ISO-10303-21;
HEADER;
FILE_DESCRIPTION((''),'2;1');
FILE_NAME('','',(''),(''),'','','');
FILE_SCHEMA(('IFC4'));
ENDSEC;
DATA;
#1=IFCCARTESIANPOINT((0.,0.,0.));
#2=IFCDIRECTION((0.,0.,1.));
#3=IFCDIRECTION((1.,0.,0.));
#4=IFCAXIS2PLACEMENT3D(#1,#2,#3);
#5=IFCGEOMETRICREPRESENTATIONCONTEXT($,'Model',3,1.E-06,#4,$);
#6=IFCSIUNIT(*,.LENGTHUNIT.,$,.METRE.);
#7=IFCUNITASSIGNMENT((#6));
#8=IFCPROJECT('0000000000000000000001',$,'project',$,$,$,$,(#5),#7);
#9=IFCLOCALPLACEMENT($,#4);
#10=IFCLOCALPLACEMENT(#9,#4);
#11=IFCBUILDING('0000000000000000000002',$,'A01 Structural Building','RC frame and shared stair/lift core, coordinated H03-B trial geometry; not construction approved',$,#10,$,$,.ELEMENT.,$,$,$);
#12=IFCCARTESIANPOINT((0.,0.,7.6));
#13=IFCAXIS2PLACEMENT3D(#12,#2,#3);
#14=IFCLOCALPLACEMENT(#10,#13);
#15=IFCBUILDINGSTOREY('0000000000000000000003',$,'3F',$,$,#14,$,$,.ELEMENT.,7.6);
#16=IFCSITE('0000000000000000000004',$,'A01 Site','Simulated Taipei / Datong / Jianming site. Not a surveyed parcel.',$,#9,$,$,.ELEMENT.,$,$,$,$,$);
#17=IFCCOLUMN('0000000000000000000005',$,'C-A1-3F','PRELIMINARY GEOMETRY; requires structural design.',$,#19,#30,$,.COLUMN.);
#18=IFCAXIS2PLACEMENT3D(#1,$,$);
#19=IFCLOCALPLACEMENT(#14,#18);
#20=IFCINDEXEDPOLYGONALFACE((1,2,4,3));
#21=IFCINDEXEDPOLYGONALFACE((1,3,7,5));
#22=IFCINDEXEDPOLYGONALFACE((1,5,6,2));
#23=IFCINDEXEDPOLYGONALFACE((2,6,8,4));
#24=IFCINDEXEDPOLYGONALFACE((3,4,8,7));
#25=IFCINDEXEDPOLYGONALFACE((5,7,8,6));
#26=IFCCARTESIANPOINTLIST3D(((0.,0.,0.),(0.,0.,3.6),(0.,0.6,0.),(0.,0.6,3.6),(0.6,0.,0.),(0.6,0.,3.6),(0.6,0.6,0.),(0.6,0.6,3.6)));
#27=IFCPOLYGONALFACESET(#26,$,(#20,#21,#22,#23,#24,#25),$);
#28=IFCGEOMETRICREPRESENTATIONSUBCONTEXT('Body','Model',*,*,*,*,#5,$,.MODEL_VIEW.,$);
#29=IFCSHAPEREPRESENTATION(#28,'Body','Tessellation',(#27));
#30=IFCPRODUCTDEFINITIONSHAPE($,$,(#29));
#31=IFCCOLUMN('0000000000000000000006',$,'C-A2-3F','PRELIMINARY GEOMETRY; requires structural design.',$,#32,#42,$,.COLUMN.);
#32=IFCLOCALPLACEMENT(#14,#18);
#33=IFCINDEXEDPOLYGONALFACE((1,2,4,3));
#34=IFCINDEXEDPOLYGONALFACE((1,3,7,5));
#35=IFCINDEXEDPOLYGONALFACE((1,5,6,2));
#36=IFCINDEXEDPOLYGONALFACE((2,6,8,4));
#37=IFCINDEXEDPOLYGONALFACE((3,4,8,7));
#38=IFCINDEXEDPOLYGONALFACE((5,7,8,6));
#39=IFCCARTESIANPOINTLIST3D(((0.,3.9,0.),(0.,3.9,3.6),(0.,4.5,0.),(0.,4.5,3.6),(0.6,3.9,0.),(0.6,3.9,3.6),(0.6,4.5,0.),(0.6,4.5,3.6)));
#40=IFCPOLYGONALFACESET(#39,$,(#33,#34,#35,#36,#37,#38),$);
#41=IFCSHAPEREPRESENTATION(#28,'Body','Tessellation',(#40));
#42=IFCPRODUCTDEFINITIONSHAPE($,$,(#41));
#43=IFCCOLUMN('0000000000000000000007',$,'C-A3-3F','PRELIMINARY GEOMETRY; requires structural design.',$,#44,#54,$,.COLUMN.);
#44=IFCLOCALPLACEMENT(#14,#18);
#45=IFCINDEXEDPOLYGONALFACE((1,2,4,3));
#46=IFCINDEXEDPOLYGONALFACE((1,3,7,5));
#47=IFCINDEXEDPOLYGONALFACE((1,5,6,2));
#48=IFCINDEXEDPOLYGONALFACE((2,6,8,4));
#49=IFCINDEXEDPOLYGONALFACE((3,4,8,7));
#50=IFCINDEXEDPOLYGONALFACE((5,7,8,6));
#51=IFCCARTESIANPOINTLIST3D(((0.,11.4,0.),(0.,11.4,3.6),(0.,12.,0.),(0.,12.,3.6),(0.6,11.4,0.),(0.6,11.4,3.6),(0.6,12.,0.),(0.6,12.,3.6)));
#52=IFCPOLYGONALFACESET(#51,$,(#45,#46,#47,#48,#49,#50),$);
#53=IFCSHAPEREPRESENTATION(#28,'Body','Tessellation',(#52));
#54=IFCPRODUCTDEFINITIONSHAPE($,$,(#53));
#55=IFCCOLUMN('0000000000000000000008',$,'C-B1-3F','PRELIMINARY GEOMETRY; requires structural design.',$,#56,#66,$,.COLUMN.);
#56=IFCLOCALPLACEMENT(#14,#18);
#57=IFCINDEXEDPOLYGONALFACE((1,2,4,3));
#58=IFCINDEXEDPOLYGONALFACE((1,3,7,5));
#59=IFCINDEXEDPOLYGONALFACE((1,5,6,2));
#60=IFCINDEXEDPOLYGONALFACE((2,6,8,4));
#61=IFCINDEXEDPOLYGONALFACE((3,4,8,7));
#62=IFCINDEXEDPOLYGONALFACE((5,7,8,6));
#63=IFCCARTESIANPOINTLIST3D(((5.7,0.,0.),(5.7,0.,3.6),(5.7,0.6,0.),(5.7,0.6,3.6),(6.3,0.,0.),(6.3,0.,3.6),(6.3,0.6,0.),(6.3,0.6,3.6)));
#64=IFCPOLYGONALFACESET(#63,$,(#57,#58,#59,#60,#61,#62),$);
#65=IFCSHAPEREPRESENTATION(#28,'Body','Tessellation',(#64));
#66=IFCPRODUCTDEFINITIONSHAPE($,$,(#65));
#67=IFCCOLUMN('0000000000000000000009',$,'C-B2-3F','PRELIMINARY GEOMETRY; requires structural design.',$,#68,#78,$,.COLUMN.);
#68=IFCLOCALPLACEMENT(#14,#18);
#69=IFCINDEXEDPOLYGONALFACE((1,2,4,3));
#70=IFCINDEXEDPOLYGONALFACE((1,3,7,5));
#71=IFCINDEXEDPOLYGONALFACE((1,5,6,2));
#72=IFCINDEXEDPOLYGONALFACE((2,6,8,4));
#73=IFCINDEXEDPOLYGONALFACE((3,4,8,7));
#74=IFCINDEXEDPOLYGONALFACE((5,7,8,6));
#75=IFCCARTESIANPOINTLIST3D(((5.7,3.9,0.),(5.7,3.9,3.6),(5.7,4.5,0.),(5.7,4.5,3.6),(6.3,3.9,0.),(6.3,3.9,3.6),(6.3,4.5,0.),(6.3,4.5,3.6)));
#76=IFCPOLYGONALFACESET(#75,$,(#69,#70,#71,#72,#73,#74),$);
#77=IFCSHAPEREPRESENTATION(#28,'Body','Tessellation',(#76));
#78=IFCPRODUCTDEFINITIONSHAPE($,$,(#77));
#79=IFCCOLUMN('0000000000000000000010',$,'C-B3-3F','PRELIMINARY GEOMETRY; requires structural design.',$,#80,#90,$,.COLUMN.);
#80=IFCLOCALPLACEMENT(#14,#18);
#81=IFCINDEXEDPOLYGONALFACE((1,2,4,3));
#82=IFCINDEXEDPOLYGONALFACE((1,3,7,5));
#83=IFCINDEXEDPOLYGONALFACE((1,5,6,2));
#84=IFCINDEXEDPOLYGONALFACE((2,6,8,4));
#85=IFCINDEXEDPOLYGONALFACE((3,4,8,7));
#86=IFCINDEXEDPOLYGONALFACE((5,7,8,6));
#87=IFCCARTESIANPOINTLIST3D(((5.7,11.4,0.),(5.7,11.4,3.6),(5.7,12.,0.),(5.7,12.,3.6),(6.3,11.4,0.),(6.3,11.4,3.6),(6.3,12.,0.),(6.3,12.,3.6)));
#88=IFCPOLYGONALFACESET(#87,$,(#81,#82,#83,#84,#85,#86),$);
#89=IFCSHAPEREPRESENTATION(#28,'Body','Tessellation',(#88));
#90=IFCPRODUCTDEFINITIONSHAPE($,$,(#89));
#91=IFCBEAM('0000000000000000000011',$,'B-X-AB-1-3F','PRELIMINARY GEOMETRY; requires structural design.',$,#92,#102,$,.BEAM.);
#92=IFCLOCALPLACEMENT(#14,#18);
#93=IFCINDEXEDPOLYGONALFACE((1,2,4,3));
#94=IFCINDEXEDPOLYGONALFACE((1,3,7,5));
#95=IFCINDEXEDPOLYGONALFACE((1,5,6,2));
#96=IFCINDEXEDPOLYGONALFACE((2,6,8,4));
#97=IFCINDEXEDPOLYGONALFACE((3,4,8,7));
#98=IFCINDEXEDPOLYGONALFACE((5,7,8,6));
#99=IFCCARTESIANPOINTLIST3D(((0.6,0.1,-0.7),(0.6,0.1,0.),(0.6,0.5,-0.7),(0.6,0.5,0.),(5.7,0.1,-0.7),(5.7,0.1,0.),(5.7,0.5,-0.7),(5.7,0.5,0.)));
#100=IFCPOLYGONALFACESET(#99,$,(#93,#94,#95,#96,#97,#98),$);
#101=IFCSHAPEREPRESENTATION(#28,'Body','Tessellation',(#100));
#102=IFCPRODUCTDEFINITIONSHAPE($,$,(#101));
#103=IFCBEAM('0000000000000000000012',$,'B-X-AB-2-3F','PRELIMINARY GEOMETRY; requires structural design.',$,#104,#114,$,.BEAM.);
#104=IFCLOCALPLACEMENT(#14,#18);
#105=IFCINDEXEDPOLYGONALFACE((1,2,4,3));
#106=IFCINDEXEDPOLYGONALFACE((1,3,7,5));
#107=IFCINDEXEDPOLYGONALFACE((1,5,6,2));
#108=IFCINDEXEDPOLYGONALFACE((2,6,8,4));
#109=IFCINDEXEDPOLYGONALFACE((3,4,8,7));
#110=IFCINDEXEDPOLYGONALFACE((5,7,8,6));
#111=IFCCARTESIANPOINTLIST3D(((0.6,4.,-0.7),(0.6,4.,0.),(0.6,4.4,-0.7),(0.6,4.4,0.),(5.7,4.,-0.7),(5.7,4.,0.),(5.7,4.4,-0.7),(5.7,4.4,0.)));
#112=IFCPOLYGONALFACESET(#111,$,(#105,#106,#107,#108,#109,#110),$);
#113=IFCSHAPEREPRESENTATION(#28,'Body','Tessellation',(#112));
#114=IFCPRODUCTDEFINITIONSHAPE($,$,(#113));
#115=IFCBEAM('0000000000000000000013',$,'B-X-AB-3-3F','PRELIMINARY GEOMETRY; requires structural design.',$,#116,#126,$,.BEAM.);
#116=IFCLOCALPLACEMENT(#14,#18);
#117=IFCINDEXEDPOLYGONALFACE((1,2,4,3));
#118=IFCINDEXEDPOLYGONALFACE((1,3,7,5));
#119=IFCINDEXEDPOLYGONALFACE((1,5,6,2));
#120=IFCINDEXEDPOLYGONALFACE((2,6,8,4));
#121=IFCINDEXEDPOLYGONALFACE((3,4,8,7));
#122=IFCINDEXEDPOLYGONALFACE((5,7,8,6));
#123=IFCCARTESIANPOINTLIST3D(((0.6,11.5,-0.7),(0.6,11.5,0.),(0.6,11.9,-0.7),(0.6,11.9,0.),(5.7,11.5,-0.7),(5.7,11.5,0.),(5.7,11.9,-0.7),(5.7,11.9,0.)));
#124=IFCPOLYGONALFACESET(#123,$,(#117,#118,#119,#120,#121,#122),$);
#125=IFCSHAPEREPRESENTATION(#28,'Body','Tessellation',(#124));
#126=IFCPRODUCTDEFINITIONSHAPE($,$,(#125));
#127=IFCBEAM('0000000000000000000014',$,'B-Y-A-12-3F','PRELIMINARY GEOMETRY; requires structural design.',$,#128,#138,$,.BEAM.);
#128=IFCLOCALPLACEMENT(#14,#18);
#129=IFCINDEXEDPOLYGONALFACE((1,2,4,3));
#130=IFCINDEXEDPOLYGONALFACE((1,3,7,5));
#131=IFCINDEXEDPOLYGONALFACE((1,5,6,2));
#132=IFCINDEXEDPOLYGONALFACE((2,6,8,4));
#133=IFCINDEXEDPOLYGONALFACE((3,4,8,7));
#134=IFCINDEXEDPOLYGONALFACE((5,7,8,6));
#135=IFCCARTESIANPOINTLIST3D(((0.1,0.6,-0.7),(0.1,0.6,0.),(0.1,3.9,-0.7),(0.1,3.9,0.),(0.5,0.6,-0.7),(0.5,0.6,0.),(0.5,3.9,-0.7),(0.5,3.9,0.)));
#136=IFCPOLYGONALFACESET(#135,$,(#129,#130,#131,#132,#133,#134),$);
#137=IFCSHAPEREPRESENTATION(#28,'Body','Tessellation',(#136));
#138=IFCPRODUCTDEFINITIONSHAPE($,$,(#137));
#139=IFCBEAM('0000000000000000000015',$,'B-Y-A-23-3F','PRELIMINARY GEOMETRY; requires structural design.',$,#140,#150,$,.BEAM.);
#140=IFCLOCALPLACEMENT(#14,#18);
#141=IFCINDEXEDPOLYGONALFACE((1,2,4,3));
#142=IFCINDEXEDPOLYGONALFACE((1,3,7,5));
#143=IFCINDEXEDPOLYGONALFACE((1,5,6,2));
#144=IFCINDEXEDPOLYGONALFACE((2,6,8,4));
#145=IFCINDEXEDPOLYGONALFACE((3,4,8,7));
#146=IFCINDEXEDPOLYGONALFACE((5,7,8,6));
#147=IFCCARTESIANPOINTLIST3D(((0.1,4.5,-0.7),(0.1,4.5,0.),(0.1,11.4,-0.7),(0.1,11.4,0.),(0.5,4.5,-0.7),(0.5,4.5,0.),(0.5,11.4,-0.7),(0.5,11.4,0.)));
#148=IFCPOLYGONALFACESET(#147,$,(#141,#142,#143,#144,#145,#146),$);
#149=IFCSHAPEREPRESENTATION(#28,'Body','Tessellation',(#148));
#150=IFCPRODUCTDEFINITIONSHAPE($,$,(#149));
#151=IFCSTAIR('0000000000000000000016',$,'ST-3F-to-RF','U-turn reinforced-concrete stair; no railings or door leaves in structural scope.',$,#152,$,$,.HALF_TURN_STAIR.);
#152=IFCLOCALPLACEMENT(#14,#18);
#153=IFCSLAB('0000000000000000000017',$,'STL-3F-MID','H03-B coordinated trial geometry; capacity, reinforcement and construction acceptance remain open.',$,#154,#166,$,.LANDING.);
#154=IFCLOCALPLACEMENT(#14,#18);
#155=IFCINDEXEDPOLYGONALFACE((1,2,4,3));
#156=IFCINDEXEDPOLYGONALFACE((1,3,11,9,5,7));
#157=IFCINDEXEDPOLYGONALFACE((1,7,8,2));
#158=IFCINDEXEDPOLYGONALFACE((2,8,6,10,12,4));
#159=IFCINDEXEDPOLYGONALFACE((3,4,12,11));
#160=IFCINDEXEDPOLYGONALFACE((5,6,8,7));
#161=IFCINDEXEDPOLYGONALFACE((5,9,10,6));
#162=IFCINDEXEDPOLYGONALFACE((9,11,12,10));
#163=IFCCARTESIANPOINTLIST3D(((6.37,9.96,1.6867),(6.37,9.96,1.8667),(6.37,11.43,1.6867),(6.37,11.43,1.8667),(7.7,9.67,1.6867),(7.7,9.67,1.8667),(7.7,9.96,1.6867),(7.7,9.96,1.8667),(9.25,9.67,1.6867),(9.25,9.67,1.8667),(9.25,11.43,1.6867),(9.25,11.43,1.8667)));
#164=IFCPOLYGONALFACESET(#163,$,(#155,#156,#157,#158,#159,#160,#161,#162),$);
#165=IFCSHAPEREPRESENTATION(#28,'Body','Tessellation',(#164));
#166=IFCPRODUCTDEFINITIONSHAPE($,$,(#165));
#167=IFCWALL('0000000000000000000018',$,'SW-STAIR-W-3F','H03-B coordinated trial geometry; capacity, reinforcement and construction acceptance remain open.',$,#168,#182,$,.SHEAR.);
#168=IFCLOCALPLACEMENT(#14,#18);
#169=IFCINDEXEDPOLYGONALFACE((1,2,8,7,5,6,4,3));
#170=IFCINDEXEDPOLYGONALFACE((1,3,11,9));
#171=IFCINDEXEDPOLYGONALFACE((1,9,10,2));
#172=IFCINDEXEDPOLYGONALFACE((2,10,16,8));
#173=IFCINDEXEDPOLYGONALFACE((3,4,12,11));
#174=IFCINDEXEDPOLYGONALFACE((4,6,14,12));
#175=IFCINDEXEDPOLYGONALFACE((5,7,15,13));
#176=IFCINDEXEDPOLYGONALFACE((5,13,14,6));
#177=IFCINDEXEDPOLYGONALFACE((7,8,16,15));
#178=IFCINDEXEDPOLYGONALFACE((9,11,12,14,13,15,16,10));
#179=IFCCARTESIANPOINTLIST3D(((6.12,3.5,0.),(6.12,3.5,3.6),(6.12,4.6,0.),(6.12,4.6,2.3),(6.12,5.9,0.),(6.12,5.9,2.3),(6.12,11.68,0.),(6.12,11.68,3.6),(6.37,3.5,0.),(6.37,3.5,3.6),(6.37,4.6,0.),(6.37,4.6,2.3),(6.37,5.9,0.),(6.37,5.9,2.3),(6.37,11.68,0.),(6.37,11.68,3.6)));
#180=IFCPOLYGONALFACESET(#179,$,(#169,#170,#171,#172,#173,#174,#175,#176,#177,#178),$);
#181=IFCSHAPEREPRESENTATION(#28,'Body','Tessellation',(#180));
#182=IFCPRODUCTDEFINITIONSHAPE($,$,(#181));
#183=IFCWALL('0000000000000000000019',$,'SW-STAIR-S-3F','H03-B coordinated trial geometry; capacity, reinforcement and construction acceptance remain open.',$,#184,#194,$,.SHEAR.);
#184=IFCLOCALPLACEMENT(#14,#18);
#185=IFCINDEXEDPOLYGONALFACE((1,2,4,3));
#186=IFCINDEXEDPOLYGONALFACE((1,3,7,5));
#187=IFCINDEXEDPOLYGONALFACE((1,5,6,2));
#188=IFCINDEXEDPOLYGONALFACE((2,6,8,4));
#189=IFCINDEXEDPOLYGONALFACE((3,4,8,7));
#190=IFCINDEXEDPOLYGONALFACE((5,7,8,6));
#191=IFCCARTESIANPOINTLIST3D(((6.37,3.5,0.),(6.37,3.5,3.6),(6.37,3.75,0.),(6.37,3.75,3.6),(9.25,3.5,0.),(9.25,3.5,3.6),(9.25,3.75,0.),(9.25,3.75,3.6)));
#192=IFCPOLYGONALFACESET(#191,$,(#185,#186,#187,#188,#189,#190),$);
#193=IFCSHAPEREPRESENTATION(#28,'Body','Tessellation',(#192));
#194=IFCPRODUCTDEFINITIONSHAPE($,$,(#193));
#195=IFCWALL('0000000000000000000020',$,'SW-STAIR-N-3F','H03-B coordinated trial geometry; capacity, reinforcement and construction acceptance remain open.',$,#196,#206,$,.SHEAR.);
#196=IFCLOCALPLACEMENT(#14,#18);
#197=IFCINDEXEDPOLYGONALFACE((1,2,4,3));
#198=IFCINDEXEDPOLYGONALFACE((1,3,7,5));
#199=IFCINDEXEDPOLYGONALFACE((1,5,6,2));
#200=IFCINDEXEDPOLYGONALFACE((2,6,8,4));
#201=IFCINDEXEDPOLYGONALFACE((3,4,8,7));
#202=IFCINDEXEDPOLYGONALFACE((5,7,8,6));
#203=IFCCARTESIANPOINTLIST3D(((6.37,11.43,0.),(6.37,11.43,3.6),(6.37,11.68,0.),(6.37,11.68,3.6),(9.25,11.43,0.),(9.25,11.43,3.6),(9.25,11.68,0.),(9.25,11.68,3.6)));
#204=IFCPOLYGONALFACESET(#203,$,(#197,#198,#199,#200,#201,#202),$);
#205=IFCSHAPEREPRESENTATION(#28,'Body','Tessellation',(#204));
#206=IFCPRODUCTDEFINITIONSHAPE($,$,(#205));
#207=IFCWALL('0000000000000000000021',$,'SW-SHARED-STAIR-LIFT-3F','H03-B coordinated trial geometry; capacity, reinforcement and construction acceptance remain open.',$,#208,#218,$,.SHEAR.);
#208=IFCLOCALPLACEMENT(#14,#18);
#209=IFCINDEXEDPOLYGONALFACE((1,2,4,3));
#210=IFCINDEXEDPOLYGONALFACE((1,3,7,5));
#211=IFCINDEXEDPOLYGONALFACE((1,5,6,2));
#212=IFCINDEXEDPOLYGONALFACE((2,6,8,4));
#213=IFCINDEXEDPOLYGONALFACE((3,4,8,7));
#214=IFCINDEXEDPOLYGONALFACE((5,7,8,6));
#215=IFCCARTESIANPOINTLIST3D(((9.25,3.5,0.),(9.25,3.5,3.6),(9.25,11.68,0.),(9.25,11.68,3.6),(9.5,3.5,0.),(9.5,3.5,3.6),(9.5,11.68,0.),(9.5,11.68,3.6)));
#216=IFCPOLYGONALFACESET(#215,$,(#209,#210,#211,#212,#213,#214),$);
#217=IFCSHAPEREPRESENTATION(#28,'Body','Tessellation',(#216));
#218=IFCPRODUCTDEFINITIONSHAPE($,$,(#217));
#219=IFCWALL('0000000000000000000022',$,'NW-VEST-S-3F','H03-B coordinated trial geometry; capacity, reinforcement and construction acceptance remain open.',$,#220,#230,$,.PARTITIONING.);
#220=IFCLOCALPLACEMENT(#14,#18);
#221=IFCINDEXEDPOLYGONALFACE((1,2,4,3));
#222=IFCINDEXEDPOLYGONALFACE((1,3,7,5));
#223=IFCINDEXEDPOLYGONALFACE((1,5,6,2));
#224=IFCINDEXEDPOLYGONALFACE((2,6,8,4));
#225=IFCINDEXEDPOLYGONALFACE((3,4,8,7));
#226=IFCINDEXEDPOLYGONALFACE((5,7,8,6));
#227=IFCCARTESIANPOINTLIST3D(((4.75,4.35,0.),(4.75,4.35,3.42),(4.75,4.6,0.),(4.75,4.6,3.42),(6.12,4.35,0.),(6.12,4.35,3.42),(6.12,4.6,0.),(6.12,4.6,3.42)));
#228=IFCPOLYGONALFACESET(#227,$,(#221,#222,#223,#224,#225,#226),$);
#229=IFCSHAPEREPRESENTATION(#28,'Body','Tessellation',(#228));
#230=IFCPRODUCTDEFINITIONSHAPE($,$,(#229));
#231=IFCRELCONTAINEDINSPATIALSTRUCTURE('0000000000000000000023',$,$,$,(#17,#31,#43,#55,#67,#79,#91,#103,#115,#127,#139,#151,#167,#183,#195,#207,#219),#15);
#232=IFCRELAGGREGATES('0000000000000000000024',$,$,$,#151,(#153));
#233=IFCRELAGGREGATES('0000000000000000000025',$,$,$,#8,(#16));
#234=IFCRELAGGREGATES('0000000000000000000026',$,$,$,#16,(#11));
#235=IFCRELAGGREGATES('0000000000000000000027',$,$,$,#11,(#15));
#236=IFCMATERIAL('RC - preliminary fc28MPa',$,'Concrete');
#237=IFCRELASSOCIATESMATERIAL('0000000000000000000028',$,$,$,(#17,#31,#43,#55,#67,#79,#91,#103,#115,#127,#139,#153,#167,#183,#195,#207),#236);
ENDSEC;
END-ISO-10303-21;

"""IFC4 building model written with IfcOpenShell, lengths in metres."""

from ifc_helpers import new_model, si_unit, frame, origin_with_axes, place, context, subcontext, project, spatial, polyline, rectangle, outline, extrude, material, element, aggregate, save


model = new_model("IFC4")

# Units and contexts
model_context = context("Model", 3, precision=1e-06, world=origin_with_axes())
body_context = subcontext(model_context, "Body", "Model", "MODEL_VIEW")
ifc_project = project(units=[si_unit("LENGTHUNIT", "METRE")], contexts=[model_context])

# Site, building, storey
site_placement = place(None, origin_with_axes())
site = spatial("IfcSite", under=ifc_project, at=site_placement, Name="A01 Site", Description="Simulated Taipei / Datong / Jianming site. Not a surveyed parcel.", CompositionType="ELEMENT")
building_placement = place(site_placement, origin_with_axes())
building = spatial("IfcBuilding", under=site, at=building_placement, Name="A01 Structural Building", Description="RC frame and shared stair/lift core, coordinated H03-B trial geometry; not construction approved", CompositionType="ELEMENT")
storey_placement = place(building_placement, frame((0.0, 0.0, 7.6), z_axis=(0.0, 0.0, 1.0), x_axis=(1.0, 0.0, 0.0)))
storey = spatial("IfcBuildingStorey", under=building, at=storey_placement, Name="3F", CompositionType="ELEMENT", Elevation=7.6)

# Columns
ifc_material = material(Name="RC - preliminary fc28MPa", Category="Concrete")
for number, where, z_axis, x_axis, name in (
    (1, (0.3, 0.3, 0.0), (0.0, 0.0, 1.0), (1.0, 0.0, 0.0), "C-A1-3F"),
    (2, (0.3, 4.2, 0.0), (0.0, 0.0, 1.0), (1.0, 0.0, 0.0), "C-A2-3F"),
    (3, (0.3, 11.7, 0.0), (0.0, 0.0, 1.0), (1.0, 0.0, 0.0), "C-A3-3F"),
    (4, (6.0, 0.3, 0.0), (0.0, 0.0, 1.0), (1.0, 0.0, 0.0), "C-B1-3F"),
    (5, (6.0, 4.2, 0.0), (0.0, 0.0, 1.0), (1.0, 0.0, 0.0), "C-B2-3F"),
    (6, (6.0, 11.7, 0.0), (0.0, 0.0, 1.0), (1.0, 0.0, 0.0), "C-B3-3F"),
):
    element("IfcColumn", number, at=place(storey_placement, frame(where, z_axis=z_axis, x_axis=x_axis)), inside=storey, material=ifc_material, Name=name, Description="PRELIMINARY GEOMETRY; requires structural design.", PredefinedType="COLUMN", context=body_context, shape_type="SweptSolid", body=[
        extrude(rectangle(XDim=0.6, YDim=0.6), origin_with_axes(), (0.0, 0.0, 1.0), 3.6),
    ])

# Beams
for number, where, z_axis, x_axis, name in (
    (7, (3.15, 0.3, -0.7), (0.0, 0.0, 1.0), (1.0, 0.0, 0.0), "B-X-AB-1-3F"),
    (8, (3.15, 4.2, -0.7), (0.0, 0.0, 1.0), (1.0, 0.0, 0.0), "B-X-AB-2-3F"),
    (9, (3.15, 11.7, -0.7), (0.0, 0.0, 1.0), (1.0, 0.0, 0.0), "B-X-AB-3-3F"),
):
    element("IfcBeam", number, at=place(storey_placement, frame(where, z_axis=z_axis, x_axis=x_axis)), inside=storey, material=ifc_material, Name=name, Description="PRELIMINARY GEOMETRY; requires structural design.", PredefinedType="BEAM", context=body_context, shape_type="SweptSolid", body=[
        extrude(rectangle(XDim=5.1, YDim=0.4), origin_with_axes(), (0.0, 0.0, 1.0), 0.7),
    ])
beam_1_placement = place(storey_placement, frame((0.3, 2.25, -0.7), z_axis=(0.0, 0.0, 1.0), x_axis=(1.0, 0.0, 0.0)))
element("IfcBeam", 10, at=beam_1_placement, inside=storey, material=ifc_material, Name="B-Y-A-12-3F", Description="PRELIMINARY GEOMETRY; requires structural design.", PredefinedType="BEAM", context=body_context, shape_type="SweptSolid", body=[
    extrude(rectangle(XDim=0.4, YDim=3.3), origin_with_axes(), (0.0, 0.0, 1.0), 0.7),
])
beam_2_placement = place(storey_placement, frame((0.3, 7.95, -0.7), z_axis=(0.0, 0.0, 1.0), x_axis=(1.0, 0.0, 0.0)))
element("IfcBeam", 11, at=beam_2_placement, inside=storey, material=ifc_material, Name="B-Y-A-23-3F", Description="PRELIMINARY GEOMETRY; requires structural design.", PredefinedType="BEAM", context=body_context, shape_type="SweptSolid", body=[
    extrude(rectangle(XDim=0.4, YDim=6.9), origin_with_axes(), (0.0, 0.0, 1.0), 0.7),
])

# Stair, slab
stair_placement = place(storey_placement, origin_with_axes())
stair = element("IfcStair", 12, at=stair_placement, inside=storey, Name="ST-3F-to-RF", Description="U-turn reinforced-concrete stair; no railings or door leaves in structural scope.", PredefinedType="HALF_TURN_STAIR")
placement = place(None, origin_with_axes())
slab = element("IfcSlab", 13, at=placement, material=ifc_material, Name="STL-3F-MID", Description="H03-B coordinated trial geometry; capacity, reinforcement and construction acceptance remain open.", PredefinedType="LANDING", context=body_context, shape_type="SweptSolid", body=[
    extrude(outline(polyline([(6.37, 9.96), (7.7, 9.96), (7.7, 9.67), (9.25, 9.67), (9.25, 11.43), (6.37, 11.43), (6.37, 9.96)])), frame((0.0, 0.0, 9.2867), z_axis=(0.0, 0.0, 1.0), x_axis=(1.0, 0.0, 0.0)), (0.0, 0.0, 1.0), 0.18),
])

# Wall, opening
wall_1 = element("IfcWall", 14, at=placement, inside=storey, material=ifc_material, Name="SW-STAIR-W-3F", Description="H03-B coordinated trial geometry; capacity, reinforcement and construction acceptance remain open.", PredefinedType="SHEAR", context=body_context, shape_type="SweptSolid", body=[
    extrude(outline(polyline([(6.37, 3.5), (6.37, 11.68), (6.12, 11.68), (6.12, 3.5), (6.37, 3.5)])), frame((0.0, 0.0, 7.6), z_axis=(0.0, 0.0, 1.0), x_axis=(1.0, 0.0, 0.0)), (0.0, 0.0, 1.0), 3.6),
])
element("IfcOpeningElement", 15, at=placement, cuts=wall_1, PredefinedType="OPENING", context=body_context, shape_type="SweptSolid", body=[
    extrude(outline(polyline([(6.42, 4.6), (6.42, 5.9), (6.07, 5.9), (6.07, 4.6), (6.42, 4.6)])), frame((0.0, 0.0, 7.6), z_axis=(0.0, 0.0, 1.0), x_axis=(1.0, 0.0, 0.0)), (0.0, 0.0, 1.0), 2.3),
])

# Walls
element("IfcWall", 16, at=placement, inside=storey, material=ifc_material, Name="SW-STAIR-S-3F", Description="H03-B coordinated trial geometry; capacity, reinforcement and construction acceptance remain open.", PredefinedType="SHEAR", context=body_context, shape_type="SweptSolid", body=[
    extrude(outline(polyline([(9.25, 3.5), (9.25, 3.75), (6.37, 3.75), (6.37, 3.5), (9.25, 3.5)])), frame((0.0, 0.0, 7.6), z_axis=(0.0, 0.0, 1.0), x_axis=(1.0, 0.0, 0.0)), (0.0, 0.0, 1.0), 3.6),
])
element("IfcWall", 17, at=placement, inside=storey, material=ifc_material, Name="SW-STAIR-N-3F", Description="H03-B coordinated trial geometry; capacity, reinforcement and construction acceptance remain open.", PredefinedType="SHEAR", context=body_context, shape_type="SweptSolid", body=[
    extrude(outline(polyline([(9.25, 11.43), (9.25, 11.68), (6.37, 11.68), (6.37, 11.43), (9.25, 11.43)])), frame((0.0, 0.0, 7.6), z_axis=(0.0, 0.0, 1.0), x_axis=(1.0, 0.0, 0.0)), (0.0, 0.0, 1.0), 3.6),
])
element("IfcWall", 18, at=placement, inside=storey, material=ifc_material, Name="SW-SHARED-STAIR-LIFT-3F", Description="H03-B coordinated trial geometry; capacity, reinforcement and construction acceptance remain open.", PredefinedType="SHEAR", context=body_context, shape_type="SweptSolid", body=[
    extrude(outline(polyline([(9.5, 3.5), (9.5, 11.68), (9.25, 11.68), (9.25, 3.5), (9.5, 3.5)])), frame((0.0, 0.0, 7.6), z_axis=(0.0, 0.0, 1.0), x_axis=(1.0, 0.0, 0.0)), (0.0, 0.0, 1.0), 3.6),
])

# Wall
element("IfcWall", 19, at=placement, inside=storey, Name="NW-VEST-S-3F", Description="H03-B coordinated trial geometry; capacity, reinforcement and construction acceptance remain open.", PredefinedType="PARTITIONING", context=body_context, shape_type="SweptSolid", body=[
    extrude(outline(polyline([(6.12, 4.35), (6.12, 4.6), (4.75, 4.6), (4.75, 4.35), (6.12, 4.35)])), frame((0.0, 0.0, 7.6), z_axis=(0.0, 0.0, 1.0), x_axis=(1.0, 0.0, 0.0)), (0.0, 0.0, 1.0), 3.42),
])

aggregate(stair, [slab])

save(model, "model.ifc")
